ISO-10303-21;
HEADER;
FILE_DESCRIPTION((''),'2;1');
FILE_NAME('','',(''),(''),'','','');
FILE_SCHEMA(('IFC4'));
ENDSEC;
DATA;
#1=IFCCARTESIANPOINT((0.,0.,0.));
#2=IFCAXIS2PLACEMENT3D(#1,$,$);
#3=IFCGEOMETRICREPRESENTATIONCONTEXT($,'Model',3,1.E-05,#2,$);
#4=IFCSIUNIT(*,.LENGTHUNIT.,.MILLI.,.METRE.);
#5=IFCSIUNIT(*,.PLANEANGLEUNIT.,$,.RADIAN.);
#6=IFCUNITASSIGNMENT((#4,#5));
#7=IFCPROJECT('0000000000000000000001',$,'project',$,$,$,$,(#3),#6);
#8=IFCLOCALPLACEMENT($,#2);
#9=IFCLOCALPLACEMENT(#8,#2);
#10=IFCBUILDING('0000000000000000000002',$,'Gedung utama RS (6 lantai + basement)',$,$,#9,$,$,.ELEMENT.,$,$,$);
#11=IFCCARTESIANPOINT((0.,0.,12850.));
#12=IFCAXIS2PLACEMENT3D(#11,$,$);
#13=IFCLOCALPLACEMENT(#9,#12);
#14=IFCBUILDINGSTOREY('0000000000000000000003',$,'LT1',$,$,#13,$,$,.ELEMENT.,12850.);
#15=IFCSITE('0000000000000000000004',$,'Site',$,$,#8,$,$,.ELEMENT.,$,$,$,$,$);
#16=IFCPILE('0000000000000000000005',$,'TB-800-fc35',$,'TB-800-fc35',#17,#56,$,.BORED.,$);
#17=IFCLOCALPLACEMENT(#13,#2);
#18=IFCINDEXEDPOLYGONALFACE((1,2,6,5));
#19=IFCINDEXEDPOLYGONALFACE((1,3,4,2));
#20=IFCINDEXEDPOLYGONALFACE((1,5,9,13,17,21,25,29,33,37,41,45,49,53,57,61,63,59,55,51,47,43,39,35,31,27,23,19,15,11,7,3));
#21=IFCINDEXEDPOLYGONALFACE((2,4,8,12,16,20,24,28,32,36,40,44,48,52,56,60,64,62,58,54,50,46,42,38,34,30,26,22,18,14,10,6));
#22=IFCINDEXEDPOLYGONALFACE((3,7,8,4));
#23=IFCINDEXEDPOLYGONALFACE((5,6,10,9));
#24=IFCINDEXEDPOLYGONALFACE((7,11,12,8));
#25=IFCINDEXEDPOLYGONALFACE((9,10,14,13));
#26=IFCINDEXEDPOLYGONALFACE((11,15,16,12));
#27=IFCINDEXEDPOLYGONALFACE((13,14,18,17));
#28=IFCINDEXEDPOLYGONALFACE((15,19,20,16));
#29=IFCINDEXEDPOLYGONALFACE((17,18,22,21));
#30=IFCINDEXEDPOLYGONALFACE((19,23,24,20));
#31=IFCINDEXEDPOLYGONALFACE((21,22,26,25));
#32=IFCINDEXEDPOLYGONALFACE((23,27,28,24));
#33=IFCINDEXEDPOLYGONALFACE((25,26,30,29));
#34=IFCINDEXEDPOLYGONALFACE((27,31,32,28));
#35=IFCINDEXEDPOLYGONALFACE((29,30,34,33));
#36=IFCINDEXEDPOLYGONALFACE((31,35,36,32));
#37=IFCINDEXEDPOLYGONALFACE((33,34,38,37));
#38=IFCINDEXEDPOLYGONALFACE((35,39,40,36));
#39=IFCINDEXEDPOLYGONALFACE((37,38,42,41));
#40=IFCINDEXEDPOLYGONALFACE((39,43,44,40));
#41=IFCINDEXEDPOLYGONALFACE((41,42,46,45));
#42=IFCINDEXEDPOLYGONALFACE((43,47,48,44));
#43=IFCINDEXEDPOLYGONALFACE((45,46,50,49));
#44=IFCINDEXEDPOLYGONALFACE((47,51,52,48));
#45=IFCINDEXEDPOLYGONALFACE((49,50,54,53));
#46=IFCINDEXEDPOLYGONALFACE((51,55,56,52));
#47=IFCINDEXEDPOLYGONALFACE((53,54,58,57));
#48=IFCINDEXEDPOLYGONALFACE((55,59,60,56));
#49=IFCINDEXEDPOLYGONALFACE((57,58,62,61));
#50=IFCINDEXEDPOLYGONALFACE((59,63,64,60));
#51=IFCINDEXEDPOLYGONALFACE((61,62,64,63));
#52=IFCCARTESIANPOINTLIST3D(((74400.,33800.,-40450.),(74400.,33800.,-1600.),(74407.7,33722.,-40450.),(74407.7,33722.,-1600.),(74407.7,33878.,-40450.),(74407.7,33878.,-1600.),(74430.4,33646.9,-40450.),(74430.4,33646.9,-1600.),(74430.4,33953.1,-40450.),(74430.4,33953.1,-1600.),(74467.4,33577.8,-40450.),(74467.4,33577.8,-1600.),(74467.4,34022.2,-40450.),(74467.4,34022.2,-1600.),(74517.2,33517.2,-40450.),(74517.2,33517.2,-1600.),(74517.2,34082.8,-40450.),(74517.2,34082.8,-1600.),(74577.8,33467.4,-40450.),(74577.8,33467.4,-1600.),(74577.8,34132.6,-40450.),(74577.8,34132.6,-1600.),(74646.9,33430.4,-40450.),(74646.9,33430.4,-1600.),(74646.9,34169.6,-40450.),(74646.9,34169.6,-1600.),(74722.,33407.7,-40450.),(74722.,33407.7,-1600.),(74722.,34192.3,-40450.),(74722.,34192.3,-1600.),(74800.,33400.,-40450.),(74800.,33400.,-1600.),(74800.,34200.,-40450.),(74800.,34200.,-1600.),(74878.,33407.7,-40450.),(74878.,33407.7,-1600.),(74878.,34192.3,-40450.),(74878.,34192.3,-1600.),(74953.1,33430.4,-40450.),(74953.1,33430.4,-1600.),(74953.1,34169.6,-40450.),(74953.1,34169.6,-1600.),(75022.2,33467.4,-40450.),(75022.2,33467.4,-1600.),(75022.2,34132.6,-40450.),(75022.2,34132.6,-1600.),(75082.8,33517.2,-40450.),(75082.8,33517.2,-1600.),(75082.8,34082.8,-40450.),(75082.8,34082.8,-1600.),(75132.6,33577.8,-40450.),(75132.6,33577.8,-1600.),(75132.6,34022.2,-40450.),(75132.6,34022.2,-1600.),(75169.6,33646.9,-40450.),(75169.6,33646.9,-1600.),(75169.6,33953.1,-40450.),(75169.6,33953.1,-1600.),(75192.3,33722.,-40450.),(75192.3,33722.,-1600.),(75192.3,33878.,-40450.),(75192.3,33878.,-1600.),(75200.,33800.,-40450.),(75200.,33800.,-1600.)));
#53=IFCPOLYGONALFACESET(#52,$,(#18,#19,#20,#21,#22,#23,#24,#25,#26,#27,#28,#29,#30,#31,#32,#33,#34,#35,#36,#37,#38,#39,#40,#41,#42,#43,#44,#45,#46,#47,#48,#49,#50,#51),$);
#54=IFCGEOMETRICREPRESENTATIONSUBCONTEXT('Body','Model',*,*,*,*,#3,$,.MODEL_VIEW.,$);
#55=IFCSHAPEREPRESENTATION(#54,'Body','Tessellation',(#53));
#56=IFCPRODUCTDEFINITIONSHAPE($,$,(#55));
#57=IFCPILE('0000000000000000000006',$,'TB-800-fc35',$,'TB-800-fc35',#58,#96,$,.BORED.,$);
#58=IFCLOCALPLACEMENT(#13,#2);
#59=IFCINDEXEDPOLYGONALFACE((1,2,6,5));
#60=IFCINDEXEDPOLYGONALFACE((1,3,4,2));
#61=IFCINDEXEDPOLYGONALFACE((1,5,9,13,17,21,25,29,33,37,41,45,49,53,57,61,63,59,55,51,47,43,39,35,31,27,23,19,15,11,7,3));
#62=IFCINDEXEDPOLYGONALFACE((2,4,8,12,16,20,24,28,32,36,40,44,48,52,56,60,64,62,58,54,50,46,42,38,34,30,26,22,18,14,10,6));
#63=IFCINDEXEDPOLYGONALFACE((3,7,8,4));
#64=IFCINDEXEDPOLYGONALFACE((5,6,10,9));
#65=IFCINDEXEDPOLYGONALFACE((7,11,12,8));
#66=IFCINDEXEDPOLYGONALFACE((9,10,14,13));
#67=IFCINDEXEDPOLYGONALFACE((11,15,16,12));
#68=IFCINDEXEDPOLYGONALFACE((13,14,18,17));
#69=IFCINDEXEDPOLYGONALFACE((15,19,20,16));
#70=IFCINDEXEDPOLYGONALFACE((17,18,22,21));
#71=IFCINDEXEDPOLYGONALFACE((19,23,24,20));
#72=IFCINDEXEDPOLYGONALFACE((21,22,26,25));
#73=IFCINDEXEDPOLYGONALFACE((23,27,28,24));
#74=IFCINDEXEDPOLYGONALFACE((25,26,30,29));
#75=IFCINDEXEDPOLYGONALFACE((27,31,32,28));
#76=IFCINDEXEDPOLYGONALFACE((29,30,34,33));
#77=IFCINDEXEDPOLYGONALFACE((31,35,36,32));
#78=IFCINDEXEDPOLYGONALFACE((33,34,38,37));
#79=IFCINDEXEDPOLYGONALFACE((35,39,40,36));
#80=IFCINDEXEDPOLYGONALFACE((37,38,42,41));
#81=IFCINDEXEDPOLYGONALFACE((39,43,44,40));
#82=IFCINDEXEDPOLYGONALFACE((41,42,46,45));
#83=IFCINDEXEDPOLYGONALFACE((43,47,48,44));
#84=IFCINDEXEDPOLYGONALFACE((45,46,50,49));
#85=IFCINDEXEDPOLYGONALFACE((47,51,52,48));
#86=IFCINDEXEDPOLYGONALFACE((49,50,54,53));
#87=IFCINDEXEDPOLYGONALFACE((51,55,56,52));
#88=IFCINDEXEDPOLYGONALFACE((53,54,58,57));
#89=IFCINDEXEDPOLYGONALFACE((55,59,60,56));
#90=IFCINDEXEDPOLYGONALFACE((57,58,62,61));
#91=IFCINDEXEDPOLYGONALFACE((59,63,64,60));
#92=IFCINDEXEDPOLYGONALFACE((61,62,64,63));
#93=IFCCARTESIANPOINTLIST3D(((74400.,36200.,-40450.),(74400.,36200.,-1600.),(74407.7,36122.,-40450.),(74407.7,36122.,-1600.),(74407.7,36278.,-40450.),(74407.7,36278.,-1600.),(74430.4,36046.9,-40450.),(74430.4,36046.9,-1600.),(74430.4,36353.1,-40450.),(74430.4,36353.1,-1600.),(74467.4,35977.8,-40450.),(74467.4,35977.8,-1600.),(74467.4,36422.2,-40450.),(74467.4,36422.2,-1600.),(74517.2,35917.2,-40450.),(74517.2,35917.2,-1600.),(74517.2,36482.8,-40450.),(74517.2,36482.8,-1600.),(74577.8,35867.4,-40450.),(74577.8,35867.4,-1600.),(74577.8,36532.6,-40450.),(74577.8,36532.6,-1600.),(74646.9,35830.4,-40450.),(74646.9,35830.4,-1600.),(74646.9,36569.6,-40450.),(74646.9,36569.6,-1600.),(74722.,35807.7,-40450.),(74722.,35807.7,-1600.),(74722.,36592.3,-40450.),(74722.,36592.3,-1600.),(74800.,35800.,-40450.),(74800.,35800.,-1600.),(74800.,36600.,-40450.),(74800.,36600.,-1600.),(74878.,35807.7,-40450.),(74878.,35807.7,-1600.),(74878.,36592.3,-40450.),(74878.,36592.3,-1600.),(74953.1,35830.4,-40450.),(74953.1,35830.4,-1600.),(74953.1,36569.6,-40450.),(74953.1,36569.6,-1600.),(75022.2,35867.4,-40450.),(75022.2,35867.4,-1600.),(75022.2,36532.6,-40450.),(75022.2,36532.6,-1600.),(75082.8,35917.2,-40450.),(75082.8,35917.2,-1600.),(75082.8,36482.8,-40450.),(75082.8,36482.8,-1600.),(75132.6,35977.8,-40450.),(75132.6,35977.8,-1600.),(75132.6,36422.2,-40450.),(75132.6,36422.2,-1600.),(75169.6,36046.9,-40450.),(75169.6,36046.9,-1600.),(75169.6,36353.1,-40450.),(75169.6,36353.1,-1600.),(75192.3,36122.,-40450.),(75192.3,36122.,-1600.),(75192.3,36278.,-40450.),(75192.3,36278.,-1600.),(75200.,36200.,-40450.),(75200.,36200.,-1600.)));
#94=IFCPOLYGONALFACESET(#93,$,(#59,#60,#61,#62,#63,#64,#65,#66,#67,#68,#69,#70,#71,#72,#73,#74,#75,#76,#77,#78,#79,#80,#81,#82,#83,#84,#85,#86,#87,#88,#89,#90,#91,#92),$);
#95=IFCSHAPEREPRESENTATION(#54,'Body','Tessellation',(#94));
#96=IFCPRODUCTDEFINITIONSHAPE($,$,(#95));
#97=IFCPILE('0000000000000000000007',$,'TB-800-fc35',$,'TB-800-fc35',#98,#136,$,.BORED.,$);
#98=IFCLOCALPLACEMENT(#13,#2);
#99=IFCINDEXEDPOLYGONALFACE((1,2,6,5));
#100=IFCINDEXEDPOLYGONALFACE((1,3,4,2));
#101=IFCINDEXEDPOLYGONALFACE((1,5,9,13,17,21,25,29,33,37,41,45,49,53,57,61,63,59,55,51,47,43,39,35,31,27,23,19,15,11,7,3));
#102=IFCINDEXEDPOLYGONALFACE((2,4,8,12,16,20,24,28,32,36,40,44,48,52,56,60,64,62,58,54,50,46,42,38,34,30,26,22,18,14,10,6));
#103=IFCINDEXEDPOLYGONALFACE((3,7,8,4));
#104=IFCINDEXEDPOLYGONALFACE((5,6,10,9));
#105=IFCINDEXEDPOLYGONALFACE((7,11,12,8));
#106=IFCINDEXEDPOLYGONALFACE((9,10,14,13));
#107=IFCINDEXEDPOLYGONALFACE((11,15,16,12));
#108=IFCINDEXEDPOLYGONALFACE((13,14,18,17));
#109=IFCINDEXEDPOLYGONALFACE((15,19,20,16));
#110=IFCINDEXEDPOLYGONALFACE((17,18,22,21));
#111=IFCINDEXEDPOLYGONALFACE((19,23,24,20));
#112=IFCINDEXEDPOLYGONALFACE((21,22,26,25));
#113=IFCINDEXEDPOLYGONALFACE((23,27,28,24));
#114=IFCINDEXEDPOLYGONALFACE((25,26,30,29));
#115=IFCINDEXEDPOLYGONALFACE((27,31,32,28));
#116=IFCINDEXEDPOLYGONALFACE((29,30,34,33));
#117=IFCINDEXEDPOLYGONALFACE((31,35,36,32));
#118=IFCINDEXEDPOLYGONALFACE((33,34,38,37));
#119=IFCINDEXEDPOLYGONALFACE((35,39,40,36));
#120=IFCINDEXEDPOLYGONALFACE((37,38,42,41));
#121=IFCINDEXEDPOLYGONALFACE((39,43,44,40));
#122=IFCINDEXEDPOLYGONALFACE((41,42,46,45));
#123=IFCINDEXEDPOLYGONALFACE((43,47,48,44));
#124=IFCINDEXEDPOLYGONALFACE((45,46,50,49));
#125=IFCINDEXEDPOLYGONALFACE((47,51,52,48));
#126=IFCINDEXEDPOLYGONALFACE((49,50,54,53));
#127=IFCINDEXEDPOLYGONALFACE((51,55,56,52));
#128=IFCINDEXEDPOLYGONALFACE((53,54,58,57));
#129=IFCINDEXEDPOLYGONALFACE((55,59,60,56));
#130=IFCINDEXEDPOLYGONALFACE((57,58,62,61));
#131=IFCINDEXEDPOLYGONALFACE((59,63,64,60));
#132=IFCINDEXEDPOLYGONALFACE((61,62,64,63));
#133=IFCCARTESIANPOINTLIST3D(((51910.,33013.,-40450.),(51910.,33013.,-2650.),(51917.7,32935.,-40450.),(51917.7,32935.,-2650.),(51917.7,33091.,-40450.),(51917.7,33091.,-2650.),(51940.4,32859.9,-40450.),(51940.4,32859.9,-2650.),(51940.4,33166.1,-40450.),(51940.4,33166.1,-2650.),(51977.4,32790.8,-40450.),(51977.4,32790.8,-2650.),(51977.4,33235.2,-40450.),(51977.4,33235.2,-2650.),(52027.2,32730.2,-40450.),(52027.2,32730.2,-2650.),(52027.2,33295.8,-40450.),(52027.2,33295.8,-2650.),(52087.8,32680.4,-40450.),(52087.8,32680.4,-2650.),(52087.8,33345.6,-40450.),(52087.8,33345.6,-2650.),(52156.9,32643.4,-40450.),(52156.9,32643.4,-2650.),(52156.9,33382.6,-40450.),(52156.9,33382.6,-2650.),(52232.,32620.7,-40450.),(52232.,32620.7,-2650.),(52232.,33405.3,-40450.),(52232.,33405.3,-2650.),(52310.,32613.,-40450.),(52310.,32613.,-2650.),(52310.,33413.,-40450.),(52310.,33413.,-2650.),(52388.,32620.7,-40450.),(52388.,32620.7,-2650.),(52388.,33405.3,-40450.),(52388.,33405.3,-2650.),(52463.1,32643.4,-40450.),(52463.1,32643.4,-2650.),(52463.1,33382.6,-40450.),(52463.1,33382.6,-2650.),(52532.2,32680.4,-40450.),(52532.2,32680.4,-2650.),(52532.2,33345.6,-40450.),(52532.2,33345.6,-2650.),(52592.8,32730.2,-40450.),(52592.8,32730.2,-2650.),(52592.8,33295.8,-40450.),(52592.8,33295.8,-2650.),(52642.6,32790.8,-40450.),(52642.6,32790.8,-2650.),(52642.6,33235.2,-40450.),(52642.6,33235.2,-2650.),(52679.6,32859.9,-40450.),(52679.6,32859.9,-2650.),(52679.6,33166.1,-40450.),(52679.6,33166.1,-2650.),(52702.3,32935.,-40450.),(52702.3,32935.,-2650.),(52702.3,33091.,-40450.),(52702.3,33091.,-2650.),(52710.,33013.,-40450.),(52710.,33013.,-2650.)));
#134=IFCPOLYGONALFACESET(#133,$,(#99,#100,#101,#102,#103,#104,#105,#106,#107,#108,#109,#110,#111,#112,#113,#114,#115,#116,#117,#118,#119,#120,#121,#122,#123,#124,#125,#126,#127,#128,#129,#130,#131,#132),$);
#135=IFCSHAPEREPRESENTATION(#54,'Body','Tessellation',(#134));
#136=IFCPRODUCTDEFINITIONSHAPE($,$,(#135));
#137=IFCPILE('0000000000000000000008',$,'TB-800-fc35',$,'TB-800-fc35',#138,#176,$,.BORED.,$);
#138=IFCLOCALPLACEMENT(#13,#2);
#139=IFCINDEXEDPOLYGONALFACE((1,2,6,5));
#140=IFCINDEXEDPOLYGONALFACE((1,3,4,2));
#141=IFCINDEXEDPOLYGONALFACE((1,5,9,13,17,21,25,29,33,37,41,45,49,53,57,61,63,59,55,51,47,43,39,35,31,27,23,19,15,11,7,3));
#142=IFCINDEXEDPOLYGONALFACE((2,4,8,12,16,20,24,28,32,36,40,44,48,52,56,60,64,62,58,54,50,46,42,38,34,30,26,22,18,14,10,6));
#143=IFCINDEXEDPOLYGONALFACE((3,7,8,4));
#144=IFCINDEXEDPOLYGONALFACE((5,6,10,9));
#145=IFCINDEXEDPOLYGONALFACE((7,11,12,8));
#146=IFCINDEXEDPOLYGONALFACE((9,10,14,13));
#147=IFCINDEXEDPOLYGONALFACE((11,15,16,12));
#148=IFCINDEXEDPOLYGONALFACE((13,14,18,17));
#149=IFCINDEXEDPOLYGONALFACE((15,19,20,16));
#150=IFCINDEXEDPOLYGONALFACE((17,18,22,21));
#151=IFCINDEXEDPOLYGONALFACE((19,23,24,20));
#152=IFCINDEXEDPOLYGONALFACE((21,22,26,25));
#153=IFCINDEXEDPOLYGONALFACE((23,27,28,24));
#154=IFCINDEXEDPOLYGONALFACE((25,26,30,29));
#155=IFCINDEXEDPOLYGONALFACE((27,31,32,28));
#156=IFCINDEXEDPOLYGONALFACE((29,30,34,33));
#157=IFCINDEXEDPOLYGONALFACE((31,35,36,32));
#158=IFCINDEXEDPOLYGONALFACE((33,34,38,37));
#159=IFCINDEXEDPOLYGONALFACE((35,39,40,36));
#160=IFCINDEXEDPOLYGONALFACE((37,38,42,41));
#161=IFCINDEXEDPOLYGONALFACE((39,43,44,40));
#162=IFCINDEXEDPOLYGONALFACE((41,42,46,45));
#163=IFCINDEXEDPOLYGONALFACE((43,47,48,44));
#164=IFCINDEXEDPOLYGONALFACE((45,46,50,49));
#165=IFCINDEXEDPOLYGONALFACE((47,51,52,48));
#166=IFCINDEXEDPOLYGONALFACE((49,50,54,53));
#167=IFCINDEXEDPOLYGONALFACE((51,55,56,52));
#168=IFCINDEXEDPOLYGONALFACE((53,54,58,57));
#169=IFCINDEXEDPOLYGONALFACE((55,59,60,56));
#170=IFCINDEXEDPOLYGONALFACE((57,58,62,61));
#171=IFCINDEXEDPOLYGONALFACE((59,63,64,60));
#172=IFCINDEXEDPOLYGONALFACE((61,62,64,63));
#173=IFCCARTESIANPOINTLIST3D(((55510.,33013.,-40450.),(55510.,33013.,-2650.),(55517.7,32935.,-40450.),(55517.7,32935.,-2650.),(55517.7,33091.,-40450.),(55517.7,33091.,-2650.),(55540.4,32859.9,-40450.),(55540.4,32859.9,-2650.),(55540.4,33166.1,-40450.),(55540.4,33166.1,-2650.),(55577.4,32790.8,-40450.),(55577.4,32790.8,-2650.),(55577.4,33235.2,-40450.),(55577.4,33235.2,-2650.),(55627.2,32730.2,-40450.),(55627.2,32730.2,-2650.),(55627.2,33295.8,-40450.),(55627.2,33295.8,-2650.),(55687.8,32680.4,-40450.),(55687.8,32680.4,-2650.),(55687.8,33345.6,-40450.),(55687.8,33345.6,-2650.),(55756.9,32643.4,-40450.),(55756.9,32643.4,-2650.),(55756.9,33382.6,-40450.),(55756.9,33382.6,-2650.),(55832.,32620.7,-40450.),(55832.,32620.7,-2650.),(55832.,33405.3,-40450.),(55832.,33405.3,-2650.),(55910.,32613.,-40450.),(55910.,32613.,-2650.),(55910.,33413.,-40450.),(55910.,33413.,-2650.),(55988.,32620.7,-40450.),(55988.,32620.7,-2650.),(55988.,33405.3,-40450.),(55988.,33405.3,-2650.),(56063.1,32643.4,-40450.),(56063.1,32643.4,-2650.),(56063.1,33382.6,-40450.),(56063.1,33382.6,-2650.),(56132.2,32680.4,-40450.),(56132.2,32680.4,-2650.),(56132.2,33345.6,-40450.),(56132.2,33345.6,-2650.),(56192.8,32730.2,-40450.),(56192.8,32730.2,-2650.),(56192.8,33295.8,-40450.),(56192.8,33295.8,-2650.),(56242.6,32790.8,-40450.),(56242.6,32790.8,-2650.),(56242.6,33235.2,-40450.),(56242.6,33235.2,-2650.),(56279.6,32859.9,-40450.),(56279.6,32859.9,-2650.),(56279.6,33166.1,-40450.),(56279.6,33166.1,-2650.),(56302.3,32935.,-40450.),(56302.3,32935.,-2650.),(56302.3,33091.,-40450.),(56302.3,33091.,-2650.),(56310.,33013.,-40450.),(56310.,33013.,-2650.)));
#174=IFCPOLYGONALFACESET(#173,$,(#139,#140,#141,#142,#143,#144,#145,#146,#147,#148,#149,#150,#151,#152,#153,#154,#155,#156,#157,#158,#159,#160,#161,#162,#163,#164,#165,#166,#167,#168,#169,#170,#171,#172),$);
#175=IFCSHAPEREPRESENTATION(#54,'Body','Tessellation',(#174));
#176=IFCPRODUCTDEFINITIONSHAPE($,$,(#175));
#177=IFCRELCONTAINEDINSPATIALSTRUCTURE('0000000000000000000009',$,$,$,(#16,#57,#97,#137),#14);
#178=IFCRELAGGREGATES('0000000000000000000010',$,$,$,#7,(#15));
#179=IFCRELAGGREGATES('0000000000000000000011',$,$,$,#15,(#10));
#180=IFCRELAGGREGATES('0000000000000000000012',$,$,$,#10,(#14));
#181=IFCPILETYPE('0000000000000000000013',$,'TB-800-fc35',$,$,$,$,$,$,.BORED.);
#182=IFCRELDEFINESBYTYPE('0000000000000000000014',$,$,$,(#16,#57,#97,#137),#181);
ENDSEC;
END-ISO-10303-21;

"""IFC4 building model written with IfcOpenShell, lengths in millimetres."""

from ifc_helpers import new_model, si_unit, frame, origin, origin_2d, place, context, subcontext, project, spatial, circle, extrude, material_profile, profile_set, profile_usage, type_object, element, save


model = new_model("IFC4")

# Units and contexts
model_context = context("Model", 3, precision=1e-05, world=origin())
body_context = subcontext(model_context, "Body", "Model", "MODEL_VIEW")
ifc_project = project(units=[si_unit("LENGTHUNIT", "METRE", prefix="MILLI"), si_unit("PLANEANGLEUNIT", "RADIAN")], contexts=[model_context])

# Site, building, storey
site_placement = place(None, origin())
site = spatial("IfcSite", under=ifc_project, at=site_placement, Name="Site", CompositionType="ELEMENT")
building_placement = place(site_placement, origin())
building = spatial("IfcBuilding", under=site, at=building_placement, Name="Gedung utama RS (6 lantai + basement)", CompositionType="ELEMENT")
storey_placement = place(building_placement, frame((0.0, 0.0, 12850.0)))
storey = spatial("IfcBuildingStorey", under=building, at=storey_placement, Name="LT1", CompositionType="ELEMENT", Elevation=12850.0)

# Piles
ifc_material_profile = material_profile(None, circle(Radius=400.0, at=origin_2d()), Name="TB-800-fc35")
ifc_profile_set = profile_set([ifc_material_profile], Name="TB-800-fc35")
ifc_profile_usage = profile_usage(ifc_profile_set, cardinal=5)
pile_type = type_object("IfcPileType", Name="TB-800-fc35", PredefinedType="BORED", material=ifc_profile_set)
for number, where, z_axis, x_axis, name in (
    (1, (74800.0, 33800.0, -40450.0), (0.0, 0.0, 1.0), (1.0, 0.0, 0.0), "TB-800-fc35"),
    (2, (74800.0, 36200.0, -40450.0), (0.0, 0.0, 1.0), (1.0, 0.0, 0.0), "TB-800-fc35"),
):
    element("IfcPile", number, at=place(storey_placement, frame(where, z_axis=z_axis, x_axis=x_axis)), inside=storey, type_object=pile_type, material=ifc_profile_usage, Name=name, ObjectType="TB-800-fc35", PredefinedType="BORED", context=body_context, shape_type="SweptSolid", body=[
        extrude(circle(Radius=400.0, at=origin_2d()), origin(), (0.0, 0.0, 1.0), 38850.0),
    ])
for number, where, z_axis, x_axis, name in (
    (3, (52310.0, 33013.0, -40450.0), (0.0, 0.0, 1.0), (1.0, 0.0, 0.0), "TB-800-fc35"),
    (4, (55910.0, 33013.0, -40450.0), (0.0, 0.0, 1.0), (1.0, 0.0, 0.0), "TB-800-fc35"),
):
    element("IfcPile", number, at=place(storey_placement, frame(where, z_axis=z_axis, x_axis=x_axis)), inside=storey, type_object=pile_type, material=ifc_profile_usage, Name=name, ObjectType="TB-800-fc35", PredefinedType="BORED", context=body_context, shape_type="SweptSolid", body=[
        extrude(circle(Radius=400.0, at=origin_2d()), origin(), (0.0, 0.0, 1.0), 37800.0),
    ])

save(model, "model.ifc")
